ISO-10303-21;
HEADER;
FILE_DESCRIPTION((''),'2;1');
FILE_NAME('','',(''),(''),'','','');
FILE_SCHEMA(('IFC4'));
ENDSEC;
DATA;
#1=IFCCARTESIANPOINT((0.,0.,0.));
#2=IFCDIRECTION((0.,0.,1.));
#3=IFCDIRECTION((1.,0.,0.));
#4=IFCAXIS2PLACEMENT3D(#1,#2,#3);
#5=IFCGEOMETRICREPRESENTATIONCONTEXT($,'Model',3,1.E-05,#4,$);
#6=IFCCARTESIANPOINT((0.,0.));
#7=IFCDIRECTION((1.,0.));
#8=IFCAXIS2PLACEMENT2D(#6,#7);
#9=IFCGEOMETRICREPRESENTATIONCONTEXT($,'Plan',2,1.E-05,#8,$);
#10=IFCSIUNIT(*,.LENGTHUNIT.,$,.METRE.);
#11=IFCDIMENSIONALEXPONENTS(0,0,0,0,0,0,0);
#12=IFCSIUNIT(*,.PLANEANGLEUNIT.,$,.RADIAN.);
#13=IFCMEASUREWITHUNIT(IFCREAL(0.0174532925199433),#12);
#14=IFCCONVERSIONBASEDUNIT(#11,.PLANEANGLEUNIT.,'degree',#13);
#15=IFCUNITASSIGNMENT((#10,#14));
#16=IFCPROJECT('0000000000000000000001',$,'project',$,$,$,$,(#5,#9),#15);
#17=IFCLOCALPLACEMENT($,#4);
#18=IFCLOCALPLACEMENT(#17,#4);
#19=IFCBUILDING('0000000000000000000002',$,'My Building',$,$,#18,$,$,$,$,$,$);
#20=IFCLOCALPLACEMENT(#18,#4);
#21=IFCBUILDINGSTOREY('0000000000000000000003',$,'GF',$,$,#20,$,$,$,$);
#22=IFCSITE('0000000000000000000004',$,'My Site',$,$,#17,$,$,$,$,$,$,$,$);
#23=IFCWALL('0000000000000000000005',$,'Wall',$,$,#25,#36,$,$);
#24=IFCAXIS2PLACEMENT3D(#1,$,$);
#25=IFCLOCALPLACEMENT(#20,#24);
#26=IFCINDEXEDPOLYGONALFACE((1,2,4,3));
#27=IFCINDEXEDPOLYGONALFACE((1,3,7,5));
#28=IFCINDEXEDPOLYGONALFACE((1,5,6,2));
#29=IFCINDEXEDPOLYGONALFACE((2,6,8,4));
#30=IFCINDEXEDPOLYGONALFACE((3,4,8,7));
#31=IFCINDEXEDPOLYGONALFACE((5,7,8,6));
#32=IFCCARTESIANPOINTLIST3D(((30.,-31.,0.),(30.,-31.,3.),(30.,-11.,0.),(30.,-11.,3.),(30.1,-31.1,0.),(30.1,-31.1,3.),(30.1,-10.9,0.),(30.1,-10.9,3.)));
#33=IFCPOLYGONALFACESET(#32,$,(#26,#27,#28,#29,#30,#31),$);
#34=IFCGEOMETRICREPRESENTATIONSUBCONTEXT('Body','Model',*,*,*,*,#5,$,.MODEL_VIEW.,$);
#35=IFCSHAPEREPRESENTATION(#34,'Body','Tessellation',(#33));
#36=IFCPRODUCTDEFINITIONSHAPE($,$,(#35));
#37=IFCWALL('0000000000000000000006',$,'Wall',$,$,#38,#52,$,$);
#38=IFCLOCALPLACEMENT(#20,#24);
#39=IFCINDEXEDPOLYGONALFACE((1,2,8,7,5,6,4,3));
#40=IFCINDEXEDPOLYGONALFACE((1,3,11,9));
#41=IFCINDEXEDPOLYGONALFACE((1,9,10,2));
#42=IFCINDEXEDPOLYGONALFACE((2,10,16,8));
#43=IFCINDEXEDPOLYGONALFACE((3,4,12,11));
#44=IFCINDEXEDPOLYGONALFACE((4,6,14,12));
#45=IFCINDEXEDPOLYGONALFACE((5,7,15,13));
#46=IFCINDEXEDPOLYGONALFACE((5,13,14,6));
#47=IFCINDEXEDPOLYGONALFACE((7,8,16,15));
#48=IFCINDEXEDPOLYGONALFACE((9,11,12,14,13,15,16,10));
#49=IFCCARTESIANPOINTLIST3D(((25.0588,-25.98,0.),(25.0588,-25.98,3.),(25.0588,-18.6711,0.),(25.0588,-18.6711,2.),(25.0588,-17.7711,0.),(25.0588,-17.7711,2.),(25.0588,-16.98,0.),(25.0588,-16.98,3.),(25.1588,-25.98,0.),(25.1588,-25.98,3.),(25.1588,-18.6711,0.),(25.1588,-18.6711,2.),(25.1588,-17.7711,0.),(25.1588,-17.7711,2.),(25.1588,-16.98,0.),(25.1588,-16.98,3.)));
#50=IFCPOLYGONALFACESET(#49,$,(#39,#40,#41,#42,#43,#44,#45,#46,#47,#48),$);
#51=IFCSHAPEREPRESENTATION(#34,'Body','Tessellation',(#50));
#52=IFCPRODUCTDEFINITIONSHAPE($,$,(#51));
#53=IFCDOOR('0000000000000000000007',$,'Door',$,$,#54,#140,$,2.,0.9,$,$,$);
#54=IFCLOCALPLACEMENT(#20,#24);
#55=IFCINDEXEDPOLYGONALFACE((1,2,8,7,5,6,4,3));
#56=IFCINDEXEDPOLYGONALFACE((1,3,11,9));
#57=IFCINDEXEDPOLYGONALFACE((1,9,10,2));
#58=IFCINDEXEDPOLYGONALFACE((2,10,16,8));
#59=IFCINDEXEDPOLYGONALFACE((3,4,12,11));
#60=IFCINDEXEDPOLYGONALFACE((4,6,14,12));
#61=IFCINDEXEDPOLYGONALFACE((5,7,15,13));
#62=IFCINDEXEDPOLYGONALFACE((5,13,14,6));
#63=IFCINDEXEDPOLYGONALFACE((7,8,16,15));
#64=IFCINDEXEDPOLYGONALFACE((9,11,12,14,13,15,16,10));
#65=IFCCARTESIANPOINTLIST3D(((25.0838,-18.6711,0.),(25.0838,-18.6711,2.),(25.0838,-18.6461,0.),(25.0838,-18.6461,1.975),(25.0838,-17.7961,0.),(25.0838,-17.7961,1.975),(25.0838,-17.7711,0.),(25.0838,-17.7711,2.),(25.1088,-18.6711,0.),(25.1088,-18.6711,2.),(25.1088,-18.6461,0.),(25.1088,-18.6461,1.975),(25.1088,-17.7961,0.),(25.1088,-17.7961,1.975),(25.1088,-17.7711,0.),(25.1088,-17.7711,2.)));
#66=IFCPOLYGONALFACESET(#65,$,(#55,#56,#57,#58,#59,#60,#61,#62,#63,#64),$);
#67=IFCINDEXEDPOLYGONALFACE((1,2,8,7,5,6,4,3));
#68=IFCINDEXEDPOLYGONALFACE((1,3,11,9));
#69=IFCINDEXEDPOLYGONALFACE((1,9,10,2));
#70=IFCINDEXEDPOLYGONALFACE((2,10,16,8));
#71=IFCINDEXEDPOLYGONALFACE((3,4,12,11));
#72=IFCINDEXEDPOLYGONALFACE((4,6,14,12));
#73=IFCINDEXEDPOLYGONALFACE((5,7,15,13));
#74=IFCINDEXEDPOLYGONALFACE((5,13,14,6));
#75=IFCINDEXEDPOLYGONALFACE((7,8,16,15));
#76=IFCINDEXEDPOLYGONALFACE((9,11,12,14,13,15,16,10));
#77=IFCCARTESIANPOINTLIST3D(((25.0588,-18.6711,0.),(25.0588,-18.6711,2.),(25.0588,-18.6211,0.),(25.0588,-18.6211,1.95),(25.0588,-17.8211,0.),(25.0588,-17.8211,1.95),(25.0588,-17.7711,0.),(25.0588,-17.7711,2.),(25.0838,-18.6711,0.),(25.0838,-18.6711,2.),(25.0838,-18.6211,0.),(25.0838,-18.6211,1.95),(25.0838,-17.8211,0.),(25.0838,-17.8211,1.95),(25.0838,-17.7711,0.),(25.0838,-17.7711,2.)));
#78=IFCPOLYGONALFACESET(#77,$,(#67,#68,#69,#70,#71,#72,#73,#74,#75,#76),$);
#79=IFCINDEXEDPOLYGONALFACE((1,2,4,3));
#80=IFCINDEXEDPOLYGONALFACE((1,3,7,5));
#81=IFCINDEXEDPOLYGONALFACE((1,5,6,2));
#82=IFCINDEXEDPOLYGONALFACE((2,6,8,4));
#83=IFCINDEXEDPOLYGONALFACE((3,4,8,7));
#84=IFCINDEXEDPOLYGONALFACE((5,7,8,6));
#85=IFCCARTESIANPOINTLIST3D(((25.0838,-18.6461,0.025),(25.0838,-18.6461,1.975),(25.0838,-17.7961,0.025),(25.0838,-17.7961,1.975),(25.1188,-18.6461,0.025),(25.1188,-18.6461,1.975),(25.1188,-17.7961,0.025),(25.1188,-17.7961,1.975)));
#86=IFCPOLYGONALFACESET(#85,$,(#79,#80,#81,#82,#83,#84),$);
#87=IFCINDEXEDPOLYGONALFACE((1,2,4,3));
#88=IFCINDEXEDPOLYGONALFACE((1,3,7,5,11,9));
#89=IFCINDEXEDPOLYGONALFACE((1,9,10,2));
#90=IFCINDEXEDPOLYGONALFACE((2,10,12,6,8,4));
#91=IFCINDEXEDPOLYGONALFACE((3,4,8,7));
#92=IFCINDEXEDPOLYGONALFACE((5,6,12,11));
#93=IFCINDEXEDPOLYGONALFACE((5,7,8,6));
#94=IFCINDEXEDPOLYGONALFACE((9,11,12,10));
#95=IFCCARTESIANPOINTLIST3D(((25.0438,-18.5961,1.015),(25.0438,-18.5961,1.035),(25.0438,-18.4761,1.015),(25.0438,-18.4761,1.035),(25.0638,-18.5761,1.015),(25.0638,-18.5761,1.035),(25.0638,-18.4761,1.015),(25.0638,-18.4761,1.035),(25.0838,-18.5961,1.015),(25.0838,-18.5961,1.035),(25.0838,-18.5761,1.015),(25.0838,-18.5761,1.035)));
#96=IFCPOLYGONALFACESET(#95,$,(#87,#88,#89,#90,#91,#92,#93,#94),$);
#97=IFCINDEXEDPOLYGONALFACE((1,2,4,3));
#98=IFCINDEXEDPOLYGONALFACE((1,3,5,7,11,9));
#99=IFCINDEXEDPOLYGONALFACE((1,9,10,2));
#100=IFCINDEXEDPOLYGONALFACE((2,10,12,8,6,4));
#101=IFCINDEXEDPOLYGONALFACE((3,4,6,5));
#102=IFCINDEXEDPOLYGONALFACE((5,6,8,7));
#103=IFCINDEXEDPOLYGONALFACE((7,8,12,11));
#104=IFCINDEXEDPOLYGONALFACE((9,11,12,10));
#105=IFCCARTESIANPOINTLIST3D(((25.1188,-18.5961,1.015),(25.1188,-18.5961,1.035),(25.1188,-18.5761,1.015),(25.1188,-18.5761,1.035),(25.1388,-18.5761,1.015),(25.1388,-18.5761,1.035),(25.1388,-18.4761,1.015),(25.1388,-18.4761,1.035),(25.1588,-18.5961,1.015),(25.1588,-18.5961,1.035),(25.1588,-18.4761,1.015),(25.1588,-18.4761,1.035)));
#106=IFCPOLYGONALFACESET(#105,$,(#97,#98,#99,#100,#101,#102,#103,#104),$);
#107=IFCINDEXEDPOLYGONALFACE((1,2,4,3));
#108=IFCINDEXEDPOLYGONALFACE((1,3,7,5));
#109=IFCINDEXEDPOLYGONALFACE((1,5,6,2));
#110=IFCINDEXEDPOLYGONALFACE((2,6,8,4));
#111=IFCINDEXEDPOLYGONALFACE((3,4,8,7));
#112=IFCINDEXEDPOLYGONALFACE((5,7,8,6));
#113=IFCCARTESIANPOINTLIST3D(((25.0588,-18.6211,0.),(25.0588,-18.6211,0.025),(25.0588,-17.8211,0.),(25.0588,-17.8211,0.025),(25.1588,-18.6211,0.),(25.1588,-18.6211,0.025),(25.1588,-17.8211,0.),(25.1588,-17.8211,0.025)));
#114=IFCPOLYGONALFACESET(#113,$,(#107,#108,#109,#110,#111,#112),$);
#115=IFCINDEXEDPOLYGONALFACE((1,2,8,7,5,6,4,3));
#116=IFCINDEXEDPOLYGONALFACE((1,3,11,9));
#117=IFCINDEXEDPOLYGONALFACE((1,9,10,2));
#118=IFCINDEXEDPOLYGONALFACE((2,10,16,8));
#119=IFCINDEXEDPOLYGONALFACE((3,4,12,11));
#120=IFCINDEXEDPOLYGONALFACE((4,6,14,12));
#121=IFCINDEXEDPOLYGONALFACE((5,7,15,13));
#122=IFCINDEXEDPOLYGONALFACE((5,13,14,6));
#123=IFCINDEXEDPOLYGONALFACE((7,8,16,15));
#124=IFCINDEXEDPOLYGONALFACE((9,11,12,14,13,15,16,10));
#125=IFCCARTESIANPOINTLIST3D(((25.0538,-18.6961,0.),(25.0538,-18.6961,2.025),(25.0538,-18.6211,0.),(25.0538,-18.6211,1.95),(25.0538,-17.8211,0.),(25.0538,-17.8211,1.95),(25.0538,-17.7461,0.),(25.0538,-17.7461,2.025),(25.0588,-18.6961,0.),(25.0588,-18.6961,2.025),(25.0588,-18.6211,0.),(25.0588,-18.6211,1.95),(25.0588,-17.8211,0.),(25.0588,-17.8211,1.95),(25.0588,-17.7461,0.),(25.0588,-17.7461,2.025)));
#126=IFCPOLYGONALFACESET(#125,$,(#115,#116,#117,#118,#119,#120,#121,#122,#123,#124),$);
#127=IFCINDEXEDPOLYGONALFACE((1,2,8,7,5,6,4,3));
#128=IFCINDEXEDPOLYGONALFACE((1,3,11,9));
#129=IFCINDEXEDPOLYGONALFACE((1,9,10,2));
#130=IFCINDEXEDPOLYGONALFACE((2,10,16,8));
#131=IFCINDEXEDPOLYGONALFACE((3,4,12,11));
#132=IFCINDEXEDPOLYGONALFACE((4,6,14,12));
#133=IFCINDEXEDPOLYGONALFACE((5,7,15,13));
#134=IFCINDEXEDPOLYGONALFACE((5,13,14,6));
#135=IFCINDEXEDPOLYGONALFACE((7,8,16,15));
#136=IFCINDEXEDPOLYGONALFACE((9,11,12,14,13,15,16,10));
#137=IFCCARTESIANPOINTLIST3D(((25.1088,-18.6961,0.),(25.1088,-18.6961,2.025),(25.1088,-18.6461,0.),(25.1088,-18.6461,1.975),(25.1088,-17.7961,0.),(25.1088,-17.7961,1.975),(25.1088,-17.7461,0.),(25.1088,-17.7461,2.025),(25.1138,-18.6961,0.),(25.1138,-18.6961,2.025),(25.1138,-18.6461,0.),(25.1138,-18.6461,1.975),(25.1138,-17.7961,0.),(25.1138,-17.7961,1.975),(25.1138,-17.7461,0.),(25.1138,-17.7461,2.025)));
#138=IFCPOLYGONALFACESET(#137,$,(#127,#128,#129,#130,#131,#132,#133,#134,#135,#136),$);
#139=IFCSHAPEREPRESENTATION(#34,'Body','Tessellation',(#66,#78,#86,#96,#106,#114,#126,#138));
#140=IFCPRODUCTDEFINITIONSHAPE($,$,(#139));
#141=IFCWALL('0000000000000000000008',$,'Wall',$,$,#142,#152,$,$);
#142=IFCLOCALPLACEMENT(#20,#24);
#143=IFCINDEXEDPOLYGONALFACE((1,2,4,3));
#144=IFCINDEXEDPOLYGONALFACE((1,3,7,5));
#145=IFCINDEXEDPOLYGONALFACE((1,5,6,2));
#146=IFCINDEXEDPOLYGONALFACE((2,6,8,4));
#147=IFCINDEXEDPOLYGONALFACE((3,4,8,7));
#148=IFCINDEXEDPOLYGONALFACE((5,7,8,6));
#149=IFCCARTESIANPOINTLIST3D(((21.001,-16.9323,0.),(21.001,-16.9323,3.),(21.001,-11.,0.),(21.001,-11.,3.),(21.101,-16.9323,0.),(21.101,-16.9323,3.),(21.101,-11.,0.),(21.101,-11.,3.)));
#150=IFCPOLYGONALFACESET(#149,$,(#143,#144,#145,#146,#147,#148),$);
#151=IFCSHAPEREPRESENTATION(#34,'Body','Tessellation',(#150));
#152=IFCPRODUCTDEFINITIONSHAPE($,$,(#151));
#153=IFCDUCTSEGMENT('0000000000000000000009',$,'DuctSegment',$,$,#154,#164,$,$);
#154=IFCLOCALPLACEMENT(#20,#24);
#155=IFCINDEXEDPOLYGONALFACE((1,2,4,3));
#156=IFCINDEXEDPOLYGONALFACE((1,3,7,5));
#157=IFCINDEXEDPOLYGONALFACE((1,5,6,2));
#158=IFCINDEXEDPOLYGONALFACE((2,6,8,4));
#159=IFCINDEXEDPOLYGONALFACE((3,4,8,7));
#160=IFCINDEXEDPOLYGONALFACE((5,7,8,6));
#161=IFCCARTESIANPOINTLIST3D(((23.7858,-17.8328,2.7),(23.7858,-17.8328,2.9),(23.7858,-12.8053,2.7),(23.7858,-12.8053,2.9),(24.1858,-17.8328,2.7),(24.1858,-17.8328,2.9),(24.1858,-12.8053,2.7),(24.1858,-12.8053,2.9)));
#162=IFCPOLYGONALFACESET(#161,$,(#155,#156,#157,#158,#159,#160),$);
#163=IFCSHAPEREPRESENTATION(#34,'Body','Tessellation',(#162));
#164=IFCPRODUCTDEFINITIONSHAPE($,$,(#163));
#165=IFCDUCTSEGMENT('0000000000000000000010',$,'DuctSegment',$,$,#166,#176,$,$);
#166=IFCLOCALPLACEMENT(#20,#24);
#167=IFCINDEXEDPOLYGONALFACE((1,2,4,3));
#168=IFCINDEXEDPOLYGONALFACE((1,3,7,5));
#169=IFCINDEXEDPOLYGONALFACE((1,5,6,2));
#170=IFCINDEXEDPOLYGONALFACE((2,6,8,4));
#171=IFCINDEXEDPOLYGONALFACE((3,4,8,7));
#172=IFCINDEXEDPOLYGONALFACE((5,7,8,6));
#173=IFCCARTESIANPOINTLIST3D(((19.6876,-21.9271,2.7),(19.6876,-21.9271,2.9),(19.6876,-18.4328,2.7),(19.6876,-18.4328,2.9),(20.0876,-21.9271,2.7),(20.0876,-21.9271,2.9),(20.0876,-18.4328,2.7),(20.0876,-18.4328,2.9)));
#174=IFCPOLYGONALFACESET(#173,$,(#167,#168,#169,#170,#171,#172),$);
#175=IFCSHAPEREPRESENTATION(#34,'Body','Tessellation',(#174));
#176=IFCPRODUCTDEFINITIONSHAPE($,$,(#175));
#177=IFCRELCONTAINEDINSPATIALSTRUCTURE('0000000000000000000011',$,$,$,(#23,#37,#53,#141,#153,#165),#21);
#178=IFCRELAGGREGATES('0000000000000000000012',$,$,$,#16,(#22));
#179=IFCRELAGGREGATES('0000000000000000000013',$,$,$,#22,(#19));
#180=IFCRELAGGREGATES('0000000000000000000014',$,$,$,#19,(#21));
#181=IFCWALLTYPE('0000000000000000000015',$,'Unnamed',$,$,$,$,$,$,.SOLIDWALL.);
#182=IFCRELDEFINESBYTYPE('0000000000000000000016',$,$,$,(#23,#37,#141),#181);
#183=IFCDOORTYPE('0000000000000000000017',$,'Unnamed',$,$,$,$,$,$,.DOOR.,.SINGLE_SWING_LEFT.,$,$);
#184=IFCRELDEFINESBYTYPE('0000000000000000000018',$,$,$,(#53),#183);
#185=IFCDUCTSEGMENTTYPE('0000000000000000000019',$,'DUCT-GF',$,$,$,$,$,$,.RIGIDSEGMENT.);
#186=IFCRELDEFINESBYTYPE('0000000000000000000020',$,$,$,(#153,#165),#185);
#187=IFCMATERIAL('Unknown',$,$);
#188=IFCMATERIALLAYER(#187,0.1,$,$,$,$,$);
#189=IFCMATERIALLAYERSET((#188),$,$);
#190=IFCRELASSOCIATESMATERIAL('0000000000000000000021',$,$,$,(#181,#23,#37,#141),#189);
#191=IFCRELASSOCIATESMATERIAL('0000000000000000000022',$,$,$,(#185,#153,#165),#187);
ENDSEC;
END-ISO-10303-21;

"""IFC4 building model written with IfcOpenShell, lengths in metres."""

from ifc_helpers import new_model, entity, si_unit, converted_unit, frame, origin_with_axes, origin_2d_with_axis, place, context, subcontext, project, spatial, line, indexed_curve, rectangle, outline, extrude, shape, source, transform, mapped, material, layer, layer_set, layer_usage, material_profile, profile_set, profile_usage, type_object, type_shapes, element, fill, save


model = new_model("IFC4")

# Units and contexts
model_context = context("Model", 3, precision=1e-05, world=origin_with_axes())
plan_context = context("Plan", 2, precision=1e-05, world=origin_2d_with_axis())
body_context_1 = subcontext(model_context, "Body", "Model", "MODEL_VIEW")
body_context_2 = subcontext(plan_context, "Body", "Plan", "PLAN_VIEW")
ifc_project = project(units=[si_unit("LENGTHUNIT", "METRE"), converted_unit("PLANEANGLEUNIT", "degree", entity("IfcReal", 0.0174532925199433), si_unit("PLANEANGLEUNIT", "RADIAN"), dimensions=[0, 0, 0, 0, 0, 0, 0])], contexts=[model_context, plan_context])

# Site, building, storey
site_placement = place(None, origin_with_axes())
site = spatial("IfcSite", under=ifc_project, at=site_placement, Name="My Site")
building_placement = place(site_placement, origin_with_axes())
building = spatial("IfcBuilding", under=site, at=building_placement, Name="My Building")
storey_placement = place(building_placement, origin_with_axes())
storey = spatial("IfcBuildingStorey", under=building, at=storey_placement, Name="GF")

# Wall
ifc_material = material(Name="Unknown")
ifc_layer = layer(ifc_material, 0.1)
ifc_layer_set = layer_set([ifc_layer])
ifc_layer_usage_1 = layer_usage(ifc_layer_set, "AXIS2", "POSITIVE", 0.0)
wall_type = type_object("IfcWallType", Name="Unnamed", PredefinedType="SOLIDWALL", material=ifc_layer_set)
wall_1_placement = place(storey_placement, frame((30.0, -11.0, 0.0), z_axis=(0.0, 0.0, 1.0), x_axis=(0.0, -1.0, 0.0)))
element("IfcWall", 1, at=wall_1_placement, inside=storey, type_object=wall_type, material=ifc_layer_usage_1, Name="Wall", context=body_context_1, shape_type="SweptSolid", body=[
    extrude(outline(indexed_curve([(0.0, 0.0), (-0.1, 0.1), (20.1, 0.1), (20.0, 0.0)], segments=[line(1, 2, 3, 4, 1)])), origin_with_axes(), (0.0, 0.0, 1.0), 3.0),
])

# Wall, opening, door
ifc_layer_usage_2 = layer_usage(ifc_layer_set, "AXIS2", "POSITIVE", 0.0)
wall_2_placement = place(storey_placement, frame((25.0588, -16.98, 0.0), z_axis=(0.0, 0.0, 1.0), x_axis=(0.0, -1.0, 0.0)))
wall_2 = element("IfcWall", 2, at=wall_2_placement, inside=storey, type_object=wall_type, material=ifc_layer_usage_2, Name="Wall", context=body_context_1, shape_type="SweptSolid", body=[
    extrude(outline(indexed_curve([(0.0, 0.0), (0.0, 0.1), (9.0, 0.1), (9.0, 0.0)], segments=[line(1, 2, 3, 4, 1)])), origin_with_axes(), (0.0, 0.0, 1.0), 3.0),
])
shared_shape_1 = source(origin_with_axes(), body_context_1, "Body", "SweptSolid", [
    extrude(outline(indexed_curve([(0.0, 0.0), (0.9, 0.0), (0.9, 2.0), (0.0, 2.0)], segments=[line(1, 2, 3, 4, 1)])), frame((0.0, -0.6, 0.0), z_axis=(0.0, -1.0, 0.0), x_axis=(1.0, 0.0, 0.0)), (0.0, 0.0, -1.0), 1.2),
])
opening_placement = place(wall_2_placement, frame((0.7911, 0.0, 0.0), z_axis=(0.0, 0.0, 1.0), x_axis=(1.0, 0.0, 0.0)))
opening = element("IfcOpeningElement", 3, at=opening_placement, cuts=wall_2, PredefinedType="OPENING", context=body_context_1, shape_type="MappedRepresentation", body=[
    mapped(shared_shape_1, transform((0.0, 0.0, 0.0), x_axis=(1.0, 0.0, 0.0), y_axis=(0.0, 1.0, 0.0), z_axis=(0.0, 0.0, 1.0), scale=1.0)),
])
door_type = type_object("IfcDoorType", Name="Unnamed", OperationType="SINGLE_SWING_LEFT", PredefinedType="DOOR")
shared_shape_2 = source(origin_with_axes(), body_context_1, "Body", "SweptSolid", [
    extrude(outline(indexed_curve([(0.0, 0.0), (0.0, 2.0), (0.9, 2.0), (0.9, 0.0), (0.875, 0.0), (0.875, 1.975), (0.025, 1.975), (0.025, 0.0)], segments=[line(1, 2, 3, 4, 5, 6, 7, 8, 1)])), frame((0.0, 0.025, 0.0), z_axis=(0.0, -1.0, 0.0), x_axis=(1.0, 0.0, 0.0)), (0.0, 0.0, -1.0), 0.025),
    extrude(outline(indexed_curve([(0.0, 0.0), (0.0, 2.0), (0.9, 2.0), (0.9, 0.0), (0.85, 0.0), (0.85, 1.95), (0.05, 1.95), (0.05, 0.0)], segments=[line(1, 2, 3, 4, 5, 6, 7, 8, 1)])), frame((0.0, 0.0, 0.0), z_axis=(0.0, -1.0, 0.0), x_axis=(1.0, 0.0, 0.0)), (0.0, 0.0, -1.0), 0.025),
    extrude(outline(indexed_curve([(0.0, 0.0), (0.85, 0.0), (0.85, 0.035), (0.0, 0.035)], segments=[line(1, 2, 3, 4, 1)])), frame((0.025, 0.025, 0.025), z_axis=(0.0, 0.0, 1.0), x_axis=(1.0, 0.0, 0.0)), (0.0, 0.0, 1.0), 1.95),
    extrude(outline(indexed_curve([(0.0, 0.0), (0.0, -0.04), (-0.12, -0.04), (-0.12, -0.02), (-0.02, -0.02), (-0.02, 0.0)], segments=[line(1, 2, 3, 4, 5, 6, 1)])), frame((0.825, 0.025, 1.015), z_axis=(0.0, 0.0, 1.0), x_axis=(1.0, 0.0, 0.0)), (0.0, 0.0, 1.0), 0.02),
    extrude(outline(indexed_curve([(0.0, 0.0), (0.0, 0.04), (-0.12, 0.04), (-0.12, 0.02), (-0.02, 0.02), (-0.02, 0.0)], segments=[line(1, 2, 3, 4, 5, 6, 1)])), frame((0.825, 0.06, 1.015), z_axis=(0.0, 0.0, 1.0), x_axis=(1.0, 0.0, 0.0)), (0.0, 0.0, 1.0), 0.02),
    extrude(outline(indexed_curve([(0.0, 0.0), (0.8, 0.0), (0.8, 0.1), (0.0, 0.1)], segments=[line(1, 2, 3, 4, 1)])), frame((0.05, 0.0, 0.0), z_axis=(0.0, 0.0, 1.0), x_axis=(1.0, 0.0, 0.0)), (0.0, 0.0, 1.0), 0.025),
    extrude(outline(indexed_curve([(0.0, 0.0), (0.0, 2.025), (0.95, 2.025), (0.95, 0.0), (0.875, 0.0), (0.875, 1.95), (0.075, 1.95), (0.075, 0.0)], segments=[line(1, 2, 3, 4, 5, 6, 7, 8, 1)])), frame((-0.025, -0.005, 0.0), z_axis=(0.0, -1.0, 0.0), x_axis=(1.0, 0.0, 0.0)), (0.0, 0.0, -1.0), 0.005),
    extrude(outline(indexed_curve([(0.0, 0.0), (0.0, 2.025), (0.95, 2.025), (0.95, 0.0), (0.9, 0.0), (0.9, 1.975), (0.05, 1.975), (0.05, 0.0)], segments=[line(1, 2, 3, 4, 5, 6, 7, 8, 1)])), frame((-0.025, 0.05, 0.0), z_axis=(0.0, -1.0, 0.0), x_axis=(1.0, 0.0, 0.0)), (0.0, 0.0, -1.0), 0.005),
])
shared_shape_3 = source(origin_with_axes(), body_context_2, "Body", "Curve2D", [
    entity("IfcIndexedPolyCurve", entity("IfcCartesianPointList2D", [[0.0, 0.0], [0.0, 0.05], [0.025, 0.05], [0.025, 0.025], [0.05, 0.025], [0.05, 0.0]]), [entity("IfcLineIndex", [1, 2, 3, 4, 5, 6, 1])]),
    entity("IfcIndexedPolyCurve", entity("IfcCartesianPointList2D", [[0.9, 0.0], [0.9, 0.05], [0.875, 0.05], [0.875, 0.025], [0.85, 0.025], [0.85, 0.0]]), [entity("IfcLineIndex", [1, 2, 3, 4, 5, 6, 1])]),
    entity("IfcTrimmedCurve", entity("IfcEllipse", entity("IfcAxis2Placement2D", entity("IfcCartesianPoint", [0.06, 0.05]), entity("IfcDirection", [1.0, 0.0])), 0.815, 0.85), [entity("IfcCartesianPoint", [0.875, 0.05])], [entity("IfcCartesianPoint", [0.06, 0.9])], True, "CARTESIAN"),
    entity("IfcIndexedPolyCurve", entity("IfcCartesianPointList2D", [[0.025, 0.05], [0.06, 0.05], [0.06, 0.9], [0.025, 0.9]]), [entity("IfcLineIndex", [1, 2, 3, 4, 1])]),
])
type_shapes(door_type, [shared_shape_2, shared_shape_3])
door_placement = place(opening_placement, frame((0.0, 0.0, 0.0), z_axis=(0.0, 0.0, 1.0), x_axis=(1.0, 0.0, 0.0)))
door = element("IfcDoor", 4, at=door_placement, inside=storey, type_object=door_type, Name="Door", OverallHeight=2.0, OverallWidth=0.9, shapes=[
    shape(body_context_1, "Body", "MappedRepresentation", [mapped(shared_shape_2, transform((0.0, 0.0, 0.0), x_axis=(1.0, 0.0, 0.0), y_axis=(0.0, 1.0, 0.0), z_axis=(0.0, 0.0, 1.0), scale=1.0))]),
    shape(body_context_2, "Body", "MappedRepresentation", [mapped(shared_shape_3, transform((0.0, 0.0, 0.0), x_axis=(1.0, 0.0, 0.0), y_axis=(0.0, 1.0, 0.0), z_axis=(0.0, 0.0, 1.0), scale=1.0))]),
])
fill(opening, door)

# Wall
ifc_layer_usage_3 = layer_usage(ifc_layer_set, "AXIS2", "POSITIVE", 0.0)
wall_3_placement = place(storey_placement, frame((21.101, -16.9323, 0.0), z_axis=(0.0, 0.0, 1.0), x_axis=(0.0, 1.0, 0.0)))
element("IfcWall", 5, at=wall_3_placement, inside=storey, type_object=wall_type, material=ifc_layer_usage_3, Name="Wall", context=body_context_1, shape_type="SweptSolid", body=[
    extrude(outline(indexed_curve([(0.0, 0.0), (0.0, 0.1), (5.9323, 0.1), (5.9323, 0.0)], segments=[line(1, 2, 3, 4, 1)])), origin_with_axes(), (0.0, 0.0, 1.0), 3.0),
])

# Duct segments
ifc_material_profile_1 = material_profile(ifc_material, rectangle(XDim=0.4, YDim=0.2))
ifc_profile_set_1 = profile_set([ifc_material_profile_1])
ifc_profile_usage_1 = profile_usage(ifc_profile_set_1, cardinal=5)
duct_segment_type = type_object("IfcDuctSegmentType", Name="DUCT-GF", PredefinedType="RIGIDSEGMENT", material=ifc_profile_set_1)
duct_segment_1_placement = place(storey_placement, frame((23.9858, -17.8328, 2.8), z_axis=(0.0, 1.0, 0.0), x_axis=(-1.0, 0.0, 0.0)))
element("IfcDuctSegment", 6, at=duct_segment_1_placement, inside=storey, type_object=duct_segment_type, material=ifc_profile_usage_1, Name="DuctSegment", context=body_context_1, shape_type="SweptSolid", body=[
    extrude(rectangle(XDim=0.4, YDim=0.2), origin_with_axes(), (0.0, 0.0, 1.0), 5.0275),
])
ifc_profile_usage_2 = profile_usage(ifc_profile_set_1, cardinal=5)
duct_segment_2_placement = place(storey_placement, frame((19.8876, -18.4328, 2.8), z_axis=(0.0, -1.0, 0.0), x_axis=(1.0, 0.0, 0.0)))
element("IfcDuctSegment", 7, at=duct_segment_2_placement, inside=storey, type_object=duct_segment_type, material=ifc_profile_usage_2, Name="DuctSegment", context=body_context_1, shape_type="SweptSolid", body=[
    extrude(rectangle(XDim=0.4, YDim=0.2), origin_with_axes(), (0.0, 0.0, 1.0), 3.4943),
])

save(model, "model.ifc")
